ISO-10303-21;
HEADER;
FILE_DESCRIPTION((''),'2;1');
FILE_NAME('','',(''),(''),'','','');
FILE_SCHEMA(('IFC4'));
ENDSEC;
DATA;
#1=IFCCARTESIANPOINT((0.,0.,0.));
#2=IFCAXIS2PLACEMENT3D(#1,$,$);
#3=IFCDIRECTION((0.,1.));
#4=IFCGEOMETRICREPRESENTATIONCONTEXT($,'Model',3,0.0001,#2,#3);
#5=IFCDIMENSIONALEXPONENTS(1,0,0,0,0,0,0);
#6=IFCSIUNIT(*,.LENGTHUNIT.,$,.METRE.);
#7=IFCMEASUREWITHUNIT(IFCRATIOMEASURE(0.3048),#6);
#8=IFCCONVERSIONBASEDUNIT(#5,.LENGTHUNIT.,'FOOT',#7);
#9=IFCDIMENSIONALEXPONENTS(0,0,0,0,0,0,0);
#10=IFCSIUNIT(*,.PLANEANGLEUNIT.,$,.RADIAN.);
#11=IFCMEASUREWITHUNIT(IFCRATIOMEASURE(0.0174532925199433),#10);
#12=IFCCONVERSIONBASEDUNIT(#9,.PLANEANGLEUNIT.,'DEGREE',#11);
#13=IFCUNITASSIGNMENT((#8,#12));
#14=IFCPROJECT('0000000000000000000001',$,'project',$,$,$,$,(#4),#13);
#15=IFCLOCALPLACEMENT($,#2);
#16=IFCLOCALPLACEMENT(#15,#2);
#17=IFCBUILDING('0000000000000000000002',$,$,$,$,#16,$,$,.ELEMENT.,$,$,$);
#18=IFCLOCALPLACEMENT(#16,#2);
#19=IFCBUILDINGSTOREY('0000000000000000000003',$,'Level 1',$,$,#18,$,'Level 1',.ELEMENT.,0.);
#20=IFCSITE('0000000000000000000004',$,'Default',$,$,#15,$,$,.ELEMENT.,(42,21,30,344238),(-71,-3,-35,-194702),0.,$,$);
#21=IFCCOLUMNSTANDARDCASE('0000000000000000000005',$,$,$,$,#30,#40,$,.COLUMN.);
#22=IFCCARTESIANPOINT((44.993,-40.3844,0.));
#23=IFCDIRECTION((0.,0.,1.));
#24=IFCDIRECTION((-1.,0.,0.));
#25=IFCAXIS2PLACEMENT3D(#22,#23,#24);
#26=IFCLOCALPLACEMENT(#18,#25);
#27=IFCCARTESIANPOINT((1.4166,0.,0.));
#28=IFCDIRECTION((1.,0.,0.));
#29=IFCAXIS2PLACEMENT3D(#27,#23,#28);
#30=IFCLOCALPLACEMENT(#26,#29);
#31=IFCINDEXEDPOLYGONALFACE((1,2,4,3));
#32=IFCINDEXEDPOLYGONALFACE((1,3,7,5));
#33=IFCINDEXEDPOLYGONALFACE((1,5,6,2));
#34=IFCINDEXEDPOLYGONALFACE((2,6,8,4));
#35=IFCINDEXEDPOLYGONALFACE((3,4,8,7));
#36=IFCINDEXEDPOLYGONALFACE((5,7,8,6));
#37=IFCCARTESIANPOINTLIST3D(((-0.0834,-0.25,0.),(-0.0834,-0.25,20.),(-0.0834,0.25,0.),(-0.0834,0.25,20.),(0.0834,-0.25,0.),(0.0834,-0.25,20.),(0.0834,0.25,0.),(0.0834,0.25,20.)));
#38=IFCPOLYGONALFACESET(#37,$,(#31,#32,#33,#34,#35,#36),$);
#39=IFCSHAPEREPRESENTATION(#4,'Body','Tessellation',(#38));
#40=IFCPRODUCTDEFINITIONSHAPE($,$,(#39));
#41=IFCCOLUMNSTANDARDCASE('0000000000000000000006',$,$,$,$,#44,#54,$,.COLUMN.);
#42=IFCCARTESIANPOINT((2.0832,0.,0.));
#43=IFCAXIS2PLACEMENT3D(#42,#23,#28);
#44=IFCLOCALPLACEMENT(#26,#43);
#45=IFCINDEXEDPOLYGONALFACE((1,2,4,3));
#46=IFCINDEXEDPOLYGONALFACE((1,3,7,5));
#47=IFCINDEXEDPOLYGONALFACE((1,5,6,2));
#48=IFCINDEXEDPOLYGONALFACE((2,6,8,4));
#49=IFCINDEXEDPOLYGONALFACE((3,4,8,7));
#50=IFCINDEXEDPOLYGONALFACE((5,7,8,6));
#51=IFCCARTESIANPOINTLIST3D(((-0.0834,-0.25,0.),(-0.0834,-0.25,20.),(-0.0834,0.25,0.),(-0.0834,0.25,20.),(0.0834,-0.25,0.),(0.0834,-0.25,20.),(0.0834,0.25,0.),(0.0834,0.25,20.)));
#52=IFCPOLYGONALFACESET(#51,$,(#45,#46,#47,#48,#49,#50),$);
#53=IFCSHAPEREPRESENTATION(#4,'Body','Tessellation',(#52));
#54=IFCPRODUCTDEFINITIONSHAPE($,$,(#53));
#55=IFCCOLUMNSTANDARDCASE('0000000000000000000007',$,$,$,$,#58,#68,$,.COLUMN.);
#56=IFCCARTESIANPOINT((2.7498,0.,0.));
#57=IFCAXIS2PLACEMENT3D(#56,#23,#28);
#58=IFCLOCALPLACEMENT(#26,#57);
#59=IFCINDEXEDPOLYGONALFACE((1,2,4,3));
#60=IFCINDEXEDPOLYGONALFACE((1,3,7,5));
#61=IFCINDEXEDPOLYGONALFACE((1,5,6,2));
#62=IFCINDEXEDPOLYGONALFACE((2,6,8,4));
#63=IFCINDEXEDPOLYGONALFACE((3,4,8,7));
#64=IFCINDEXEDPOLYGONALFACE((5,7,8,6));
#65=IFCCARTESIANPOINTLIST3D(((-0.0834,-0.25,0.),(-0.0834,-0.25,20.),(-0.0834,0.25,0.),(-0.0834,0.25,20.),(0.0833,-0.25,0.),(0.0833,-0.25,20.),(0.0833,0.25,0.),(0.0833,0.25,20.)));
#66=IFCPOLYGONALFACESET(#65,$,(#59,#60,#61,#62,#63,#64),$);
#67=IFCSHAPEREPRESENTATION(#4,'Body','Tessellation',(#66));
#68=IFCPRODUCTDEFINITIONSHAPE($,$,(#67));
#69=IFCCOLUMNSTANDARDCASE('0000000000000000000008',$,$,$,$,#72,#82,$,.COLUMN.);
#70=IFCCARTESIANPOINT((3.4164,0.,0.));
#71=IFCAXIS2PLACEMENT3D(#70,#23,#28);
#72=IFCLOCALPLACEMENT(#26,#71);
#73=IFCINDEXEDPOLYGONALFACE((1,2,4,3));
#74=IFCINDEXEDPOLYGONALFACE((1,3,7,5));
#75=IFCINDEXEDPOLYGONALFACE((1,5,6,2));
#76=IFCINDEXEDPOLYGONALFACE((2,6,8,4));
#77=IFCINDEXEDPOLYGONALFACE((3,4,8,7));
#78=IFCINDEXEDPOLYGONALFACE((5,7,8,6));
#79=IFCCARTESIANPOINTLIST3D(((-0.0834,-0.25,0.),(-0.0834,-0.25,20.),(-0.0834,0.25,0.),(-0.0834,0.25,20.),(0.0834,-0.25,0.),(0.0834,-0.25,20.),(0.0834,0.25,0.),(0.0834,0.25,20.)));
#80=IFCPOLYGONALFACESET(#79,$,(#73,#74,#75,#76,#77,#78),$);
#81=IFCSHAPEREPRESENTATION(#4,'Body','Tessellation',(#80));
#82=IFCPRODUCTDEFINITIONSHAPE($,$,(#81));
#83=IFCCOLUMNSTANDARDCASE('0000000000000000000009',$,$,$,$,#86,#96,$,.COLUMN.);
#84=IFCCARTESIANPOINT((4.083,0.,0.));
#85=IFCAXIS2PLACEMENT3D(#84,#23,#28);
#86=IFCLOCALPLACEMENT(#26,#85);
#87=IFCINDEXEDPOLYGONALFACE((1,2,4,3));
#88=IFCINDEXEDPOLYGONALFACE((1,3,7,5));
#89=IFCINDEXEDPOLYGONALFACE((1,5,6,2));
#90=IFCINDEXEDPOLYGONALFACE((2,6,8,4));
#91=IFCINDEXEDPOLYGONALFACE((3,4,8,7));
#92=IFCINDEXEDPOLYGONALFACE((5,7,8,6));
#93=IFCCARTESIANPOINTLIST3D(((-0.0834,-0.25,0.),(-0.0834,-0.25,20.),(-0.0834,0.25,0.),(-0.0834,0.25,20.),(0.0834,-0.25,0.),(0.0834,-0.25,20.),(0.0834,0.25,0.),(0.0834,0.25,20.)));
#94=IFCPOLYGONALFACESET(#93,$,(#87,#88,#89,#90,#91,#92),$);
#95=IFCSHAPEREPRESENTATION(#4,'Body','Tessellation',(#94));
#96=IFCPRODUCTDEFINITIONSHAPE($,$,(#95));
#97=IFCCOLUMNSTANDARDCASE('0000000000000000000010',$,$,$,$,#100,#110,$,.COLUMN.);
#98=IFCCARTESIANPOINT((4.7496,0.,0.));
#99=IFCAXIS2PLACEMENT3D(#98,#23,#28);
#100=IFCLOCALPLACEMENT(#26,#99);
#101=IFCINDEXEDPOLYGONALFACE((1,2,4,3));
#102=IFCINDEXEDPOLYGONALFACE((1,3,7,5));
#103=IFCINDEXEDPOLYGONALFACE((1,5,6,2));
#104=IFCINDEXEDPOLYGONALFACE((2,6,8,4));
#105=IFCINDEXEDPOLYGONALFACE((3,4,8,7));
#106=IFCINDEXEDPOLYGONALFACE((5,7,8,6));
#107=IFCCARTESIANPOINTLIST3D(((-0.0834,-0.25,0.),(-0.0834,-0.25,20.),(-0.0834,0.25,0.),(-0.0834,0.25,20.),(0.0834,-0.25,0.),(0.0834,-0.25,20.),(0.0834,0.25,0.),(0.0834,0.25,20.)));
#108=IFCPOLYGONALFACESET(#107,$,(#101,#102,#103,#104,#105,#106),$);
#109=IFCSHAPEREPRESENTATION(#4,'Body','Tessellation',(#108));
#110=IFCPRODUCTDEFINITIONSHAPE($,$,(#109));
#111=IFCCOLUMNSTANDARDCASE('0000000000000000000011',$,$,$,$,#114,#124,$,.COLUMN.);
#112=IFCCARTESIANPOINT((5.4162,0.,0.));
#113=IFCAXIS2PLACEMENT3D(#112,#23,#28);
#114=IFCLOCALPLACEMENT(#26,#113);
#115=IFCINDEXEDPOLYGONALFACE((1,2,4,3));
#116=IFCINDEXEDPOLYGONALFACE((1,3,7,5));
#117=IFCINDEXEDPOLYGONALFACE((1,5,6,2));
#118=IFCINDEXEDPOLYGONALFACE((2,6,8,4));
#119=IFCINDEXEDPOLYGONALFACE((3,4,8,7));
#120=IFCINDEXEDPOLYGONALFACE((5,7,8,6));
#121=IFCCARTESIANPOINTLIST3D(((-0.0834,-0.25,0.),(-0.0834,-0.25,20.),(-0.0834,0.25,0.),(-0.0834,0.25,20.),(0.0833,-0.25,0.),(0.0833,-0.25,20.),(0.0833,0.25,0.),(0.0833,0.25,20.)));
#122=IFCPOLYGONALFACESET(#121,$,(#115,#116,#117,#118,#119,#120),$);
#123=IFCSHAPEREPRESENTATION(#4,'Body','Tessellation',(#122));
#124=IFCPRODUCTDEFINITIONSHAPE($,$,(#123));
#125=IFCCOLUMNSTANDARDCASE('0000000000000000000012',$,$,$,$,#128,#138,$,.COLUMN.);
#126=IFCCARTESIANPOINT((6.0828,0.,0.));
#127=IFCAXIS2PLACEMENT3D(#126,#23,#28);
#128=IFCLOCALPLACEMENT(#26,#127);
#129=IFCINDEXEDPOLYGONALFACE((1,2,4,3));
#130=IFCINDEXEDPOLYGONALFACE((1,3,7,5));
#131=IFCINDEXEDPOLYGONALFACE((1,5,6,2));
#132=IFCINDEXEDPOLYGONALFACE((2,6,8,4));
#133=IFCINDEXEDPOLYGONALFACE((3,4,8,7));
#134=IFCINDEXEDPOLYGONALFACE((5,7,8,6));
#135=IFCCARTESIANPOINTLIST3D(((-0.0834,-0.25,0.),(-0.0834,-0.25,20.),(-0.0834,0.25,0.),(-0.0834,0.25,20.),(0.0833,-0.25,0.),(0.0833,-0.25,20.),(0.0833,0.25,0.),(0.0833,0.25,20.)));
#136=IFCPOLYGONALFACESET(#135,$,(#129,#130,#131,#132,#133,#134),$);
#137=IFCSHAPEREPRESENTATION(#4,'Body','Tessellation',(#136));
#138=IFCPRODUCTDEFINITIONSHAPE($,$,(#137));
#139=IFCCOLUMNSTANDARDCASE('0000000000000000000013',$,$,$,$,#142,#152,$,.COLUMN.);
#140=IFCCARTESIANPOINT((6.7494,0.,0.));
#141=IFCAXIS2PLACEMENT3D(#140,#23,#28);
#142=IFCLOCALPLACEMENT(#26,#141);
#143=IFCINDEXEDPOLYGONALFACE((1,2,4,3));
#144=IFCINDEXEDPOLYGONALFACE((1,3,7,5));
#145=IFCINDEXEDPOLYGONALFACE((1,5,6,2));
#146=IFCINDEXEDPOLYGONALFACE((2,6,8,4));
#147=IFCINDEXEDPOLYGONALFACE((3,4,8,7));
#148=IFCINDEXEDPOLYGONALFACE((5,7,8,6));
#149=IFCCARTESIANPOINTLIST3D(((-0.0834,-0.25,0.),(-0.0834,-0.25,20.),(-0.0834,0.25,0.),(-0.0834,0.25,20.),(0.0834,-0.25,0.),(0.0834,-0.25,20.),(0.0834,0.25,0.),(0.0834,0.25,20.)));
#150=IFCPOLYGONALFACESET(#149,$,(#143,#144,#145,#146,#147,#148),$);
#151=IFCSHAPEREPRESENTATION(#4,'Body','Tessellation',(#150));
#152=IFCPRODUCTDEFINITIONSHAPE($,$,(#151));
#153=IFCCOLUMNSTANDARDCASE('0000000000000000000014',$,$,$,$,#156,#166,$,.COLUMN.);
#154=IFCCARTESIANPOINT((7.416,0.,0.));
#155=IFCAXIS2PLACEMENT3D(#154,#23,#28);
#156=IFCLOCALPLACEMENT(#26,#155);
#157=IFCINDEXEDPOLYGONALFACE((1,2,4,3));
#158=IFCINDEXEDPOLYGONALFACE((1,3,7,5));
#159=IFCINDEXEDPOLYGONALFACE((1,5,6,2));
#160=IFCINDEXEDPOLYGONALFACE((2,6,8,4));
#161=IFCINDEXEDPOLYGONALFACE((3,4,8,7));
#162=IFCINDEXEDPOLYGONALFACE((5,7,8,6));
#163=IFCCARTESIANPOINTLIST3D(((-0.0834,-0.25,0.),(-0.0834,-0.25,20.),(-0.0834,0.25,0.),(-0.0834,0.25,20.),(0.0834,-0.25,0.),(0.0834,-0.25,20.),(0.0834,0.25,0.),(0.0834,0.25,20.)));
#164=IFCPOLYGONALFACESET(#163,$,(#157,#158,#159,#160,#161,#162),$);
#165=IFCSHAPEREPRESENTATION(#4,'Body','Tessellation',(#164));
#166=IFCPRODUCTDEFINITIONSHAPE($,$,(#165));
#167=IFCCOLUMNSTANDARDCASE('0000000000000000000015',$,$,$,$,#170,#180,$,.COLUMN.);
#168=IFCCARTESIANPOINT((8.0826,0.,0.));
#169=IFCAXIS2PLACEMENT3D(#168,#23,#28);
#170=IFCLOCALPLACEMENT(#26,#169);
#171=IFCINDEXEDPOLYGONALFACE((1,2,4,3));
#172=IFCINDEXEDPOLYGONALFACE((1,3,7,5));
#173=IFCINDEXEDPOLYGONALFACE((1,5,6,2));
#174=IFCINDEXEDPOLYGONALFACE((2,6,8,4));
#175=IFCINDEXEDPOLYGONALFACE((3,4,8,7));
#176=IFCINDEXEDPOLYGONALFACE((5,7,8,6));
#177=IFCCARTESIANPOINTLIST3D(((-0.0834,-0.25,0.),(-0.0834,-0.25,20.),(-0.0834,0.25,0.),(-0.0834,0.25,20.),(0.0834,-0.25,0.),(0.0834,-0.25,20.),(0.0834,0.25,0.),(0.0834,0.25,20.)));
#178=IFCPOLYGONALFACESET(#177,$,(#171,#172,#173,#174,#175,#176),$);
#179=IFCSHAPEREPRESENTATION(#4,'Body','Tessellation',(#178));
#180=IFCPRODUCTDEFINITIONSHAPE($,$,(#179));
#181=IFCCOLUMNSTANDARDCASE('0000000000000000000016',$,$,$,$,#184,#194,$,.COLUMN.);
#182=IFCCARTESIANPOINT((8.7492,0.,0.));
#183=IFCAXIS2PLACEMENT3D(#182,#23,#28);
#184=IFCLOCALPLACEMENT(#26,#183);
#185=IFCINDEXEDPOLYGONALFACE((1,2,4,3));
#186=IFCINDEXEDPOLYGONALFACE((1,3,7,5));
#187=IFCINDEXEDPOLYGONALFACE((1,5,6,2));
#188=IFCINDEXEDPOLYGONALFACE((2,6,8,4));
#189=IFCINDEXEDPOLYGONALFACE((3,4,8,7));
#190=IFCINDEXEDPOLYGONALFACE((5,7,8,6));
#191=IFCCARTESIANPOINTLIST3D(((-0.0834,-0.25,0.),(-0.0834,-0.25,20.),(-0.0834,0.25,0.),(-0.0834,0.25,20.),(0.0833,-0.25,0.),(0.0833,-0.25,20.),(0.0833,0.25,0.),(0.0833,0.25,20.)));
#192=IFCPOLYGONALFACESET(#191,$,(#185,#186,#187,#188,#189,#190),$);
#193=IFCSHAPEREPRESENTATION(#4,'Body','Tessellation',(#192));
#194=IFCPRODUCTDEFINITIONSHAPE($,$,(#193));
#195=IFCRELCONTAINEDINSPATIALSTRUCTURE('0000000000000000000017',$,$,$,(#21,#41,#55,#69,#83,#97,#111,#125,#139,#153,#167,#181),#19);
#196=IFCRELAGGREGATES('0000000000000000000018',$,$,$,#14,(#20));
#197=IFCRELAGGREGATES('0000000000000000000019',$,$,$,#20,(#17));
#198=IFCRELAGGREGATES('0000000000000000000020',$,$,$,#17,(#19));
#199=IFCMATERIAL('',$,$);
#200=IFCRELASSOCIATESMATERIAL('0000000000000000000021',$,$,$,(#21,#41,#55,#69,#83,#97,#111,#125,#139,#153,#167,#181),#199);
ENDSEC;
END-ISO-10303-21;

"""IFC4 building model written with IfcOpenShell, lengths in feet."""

from ifc_helpers import new_model, entity, si_unit, converted_unit, direction, frame, origin, place, context, project, spatial, rectangle, extrude, material, element, save


model = new_model("IFC4")

# Units and contexts
model_context = context("Model", 3, precision=0.0001, world=origin(), true_north=direction((0.0, 1.0)))
ifc_project = project(units=[converted_unit("LENGTHUNIT", "FOOT", entity("IfcRatioMeasure", 0.3048), si_unit("LENGTHUNIT", "METRE"), dimensions=[1, 0, 0, 0, 0, 0, 0]), converted_unit("PLANEANGLEUNIT", "DEGREE", entity("IfcRatioMeasure", 0.0174532925199433), si_unit("PLANEANGLEUNIT", "RADIAN"), dimensions=[0, 0, 0, 0, 0, 0, 0])], contexts=[model_context])

# Site, building, storey
site_placement = place(None, origin())
site = spatial("IfcSite", under=ifc_project, at=site_placement, Name="Default", CompositionType="ELEMENT", RefLatitude=(42, 21, 30, 344238), RefLongitude=(-71, -3, -35, -194702), RefElevation=0.0)
building_placement = place(site_placement, origin())
building = spatial("IfcBuilding", under=site, at=building_placement, CompositionType="ELEMENT")
storey_placement = place(building_placement, origin())
storey = spatial("IfcBuildingStorey", under=building, at=storey_placement, Name="Level 1", LongName="Level 1", CompositionType="ELEMENT", Elevation=0.0)

# Columns
ifc_material_1 = material(Name="")
wall_placement = place(storey_placement, frame((44.993, -40.3844, 0.0), z_axis=(0.0, 0.0, 1.0), x_axis=(-1.0, 0.0, 0.0)))
for number, where, z_axis, x_axis in (
    (1, (1.4166, 0.0, 0.0), (0.0, 0.0, 1.0), (1.0, 0.0, 0.0)),
    (2, (2.0832, 0.0, 0.0), (0.0, 0.0, 1.0), (1.0, 0.0, 0.0)),
    (3, (2.7498, 0.0, 0.0), (0.0, 0.0, 1.0), (1.0, 0.0, 0.0)),
    (4, (3.4164, 0.0, 0.0), (0.0, 0.0, 1.0), (1.0, 0.0, 0.0)),
    (5, (4.083, 0.0, 0.0), (0.0, 0.0, 1.0), (1.0, 0.0, 0.0)),
    (6, (4.7496, 0.0, 0.0), (0.0, 0.0, 1.0), (1.0, 0.0, 0.0)),
    (7, (5.4162, 0.0, 0.0), (0.0, 0.0, 1.0), (1.0, 0.0, 0.0)),
    (8, (6.0828, 0.0, 0.0), (0.0, 0.0, 1.0), (1.0, 0.0, 0.0)),
    (9, (6.7494, 0.0, 0.0), (0.0, 0.0, 1.0), (1.0, 0.0, 0.0)),
    (10, (7.416, 0.0, 0.0), (0.0, 0.0, 1.0), (1.0, 0.0, 0.0)),
    (11, (8.0826, 0.0, 0.0), (0.0, 0.0, 1.0), (1.0, 0.0, 0.0)),
    (12, (8.7492, 0.0, 0.0), (0.0, 0.0, 1.0), (1.0, 0.0, 0.0)),
):
    element("IfcColumnStandardCase", number, at=place(wall_placement, frame(where, z_axis=z_axis, x_axis=x_axis)), inside=storey, material=ifc_material_1, PredefinedType="COLUMN", context=model_context, shape_type="SweptSolid", body=[
        extrude(rectangle(XDim=0.1667, YDim=0.5), origin(), (0.0, 0.0, 1.0), 20.0),
    ])

save(model, "model.ifc")
